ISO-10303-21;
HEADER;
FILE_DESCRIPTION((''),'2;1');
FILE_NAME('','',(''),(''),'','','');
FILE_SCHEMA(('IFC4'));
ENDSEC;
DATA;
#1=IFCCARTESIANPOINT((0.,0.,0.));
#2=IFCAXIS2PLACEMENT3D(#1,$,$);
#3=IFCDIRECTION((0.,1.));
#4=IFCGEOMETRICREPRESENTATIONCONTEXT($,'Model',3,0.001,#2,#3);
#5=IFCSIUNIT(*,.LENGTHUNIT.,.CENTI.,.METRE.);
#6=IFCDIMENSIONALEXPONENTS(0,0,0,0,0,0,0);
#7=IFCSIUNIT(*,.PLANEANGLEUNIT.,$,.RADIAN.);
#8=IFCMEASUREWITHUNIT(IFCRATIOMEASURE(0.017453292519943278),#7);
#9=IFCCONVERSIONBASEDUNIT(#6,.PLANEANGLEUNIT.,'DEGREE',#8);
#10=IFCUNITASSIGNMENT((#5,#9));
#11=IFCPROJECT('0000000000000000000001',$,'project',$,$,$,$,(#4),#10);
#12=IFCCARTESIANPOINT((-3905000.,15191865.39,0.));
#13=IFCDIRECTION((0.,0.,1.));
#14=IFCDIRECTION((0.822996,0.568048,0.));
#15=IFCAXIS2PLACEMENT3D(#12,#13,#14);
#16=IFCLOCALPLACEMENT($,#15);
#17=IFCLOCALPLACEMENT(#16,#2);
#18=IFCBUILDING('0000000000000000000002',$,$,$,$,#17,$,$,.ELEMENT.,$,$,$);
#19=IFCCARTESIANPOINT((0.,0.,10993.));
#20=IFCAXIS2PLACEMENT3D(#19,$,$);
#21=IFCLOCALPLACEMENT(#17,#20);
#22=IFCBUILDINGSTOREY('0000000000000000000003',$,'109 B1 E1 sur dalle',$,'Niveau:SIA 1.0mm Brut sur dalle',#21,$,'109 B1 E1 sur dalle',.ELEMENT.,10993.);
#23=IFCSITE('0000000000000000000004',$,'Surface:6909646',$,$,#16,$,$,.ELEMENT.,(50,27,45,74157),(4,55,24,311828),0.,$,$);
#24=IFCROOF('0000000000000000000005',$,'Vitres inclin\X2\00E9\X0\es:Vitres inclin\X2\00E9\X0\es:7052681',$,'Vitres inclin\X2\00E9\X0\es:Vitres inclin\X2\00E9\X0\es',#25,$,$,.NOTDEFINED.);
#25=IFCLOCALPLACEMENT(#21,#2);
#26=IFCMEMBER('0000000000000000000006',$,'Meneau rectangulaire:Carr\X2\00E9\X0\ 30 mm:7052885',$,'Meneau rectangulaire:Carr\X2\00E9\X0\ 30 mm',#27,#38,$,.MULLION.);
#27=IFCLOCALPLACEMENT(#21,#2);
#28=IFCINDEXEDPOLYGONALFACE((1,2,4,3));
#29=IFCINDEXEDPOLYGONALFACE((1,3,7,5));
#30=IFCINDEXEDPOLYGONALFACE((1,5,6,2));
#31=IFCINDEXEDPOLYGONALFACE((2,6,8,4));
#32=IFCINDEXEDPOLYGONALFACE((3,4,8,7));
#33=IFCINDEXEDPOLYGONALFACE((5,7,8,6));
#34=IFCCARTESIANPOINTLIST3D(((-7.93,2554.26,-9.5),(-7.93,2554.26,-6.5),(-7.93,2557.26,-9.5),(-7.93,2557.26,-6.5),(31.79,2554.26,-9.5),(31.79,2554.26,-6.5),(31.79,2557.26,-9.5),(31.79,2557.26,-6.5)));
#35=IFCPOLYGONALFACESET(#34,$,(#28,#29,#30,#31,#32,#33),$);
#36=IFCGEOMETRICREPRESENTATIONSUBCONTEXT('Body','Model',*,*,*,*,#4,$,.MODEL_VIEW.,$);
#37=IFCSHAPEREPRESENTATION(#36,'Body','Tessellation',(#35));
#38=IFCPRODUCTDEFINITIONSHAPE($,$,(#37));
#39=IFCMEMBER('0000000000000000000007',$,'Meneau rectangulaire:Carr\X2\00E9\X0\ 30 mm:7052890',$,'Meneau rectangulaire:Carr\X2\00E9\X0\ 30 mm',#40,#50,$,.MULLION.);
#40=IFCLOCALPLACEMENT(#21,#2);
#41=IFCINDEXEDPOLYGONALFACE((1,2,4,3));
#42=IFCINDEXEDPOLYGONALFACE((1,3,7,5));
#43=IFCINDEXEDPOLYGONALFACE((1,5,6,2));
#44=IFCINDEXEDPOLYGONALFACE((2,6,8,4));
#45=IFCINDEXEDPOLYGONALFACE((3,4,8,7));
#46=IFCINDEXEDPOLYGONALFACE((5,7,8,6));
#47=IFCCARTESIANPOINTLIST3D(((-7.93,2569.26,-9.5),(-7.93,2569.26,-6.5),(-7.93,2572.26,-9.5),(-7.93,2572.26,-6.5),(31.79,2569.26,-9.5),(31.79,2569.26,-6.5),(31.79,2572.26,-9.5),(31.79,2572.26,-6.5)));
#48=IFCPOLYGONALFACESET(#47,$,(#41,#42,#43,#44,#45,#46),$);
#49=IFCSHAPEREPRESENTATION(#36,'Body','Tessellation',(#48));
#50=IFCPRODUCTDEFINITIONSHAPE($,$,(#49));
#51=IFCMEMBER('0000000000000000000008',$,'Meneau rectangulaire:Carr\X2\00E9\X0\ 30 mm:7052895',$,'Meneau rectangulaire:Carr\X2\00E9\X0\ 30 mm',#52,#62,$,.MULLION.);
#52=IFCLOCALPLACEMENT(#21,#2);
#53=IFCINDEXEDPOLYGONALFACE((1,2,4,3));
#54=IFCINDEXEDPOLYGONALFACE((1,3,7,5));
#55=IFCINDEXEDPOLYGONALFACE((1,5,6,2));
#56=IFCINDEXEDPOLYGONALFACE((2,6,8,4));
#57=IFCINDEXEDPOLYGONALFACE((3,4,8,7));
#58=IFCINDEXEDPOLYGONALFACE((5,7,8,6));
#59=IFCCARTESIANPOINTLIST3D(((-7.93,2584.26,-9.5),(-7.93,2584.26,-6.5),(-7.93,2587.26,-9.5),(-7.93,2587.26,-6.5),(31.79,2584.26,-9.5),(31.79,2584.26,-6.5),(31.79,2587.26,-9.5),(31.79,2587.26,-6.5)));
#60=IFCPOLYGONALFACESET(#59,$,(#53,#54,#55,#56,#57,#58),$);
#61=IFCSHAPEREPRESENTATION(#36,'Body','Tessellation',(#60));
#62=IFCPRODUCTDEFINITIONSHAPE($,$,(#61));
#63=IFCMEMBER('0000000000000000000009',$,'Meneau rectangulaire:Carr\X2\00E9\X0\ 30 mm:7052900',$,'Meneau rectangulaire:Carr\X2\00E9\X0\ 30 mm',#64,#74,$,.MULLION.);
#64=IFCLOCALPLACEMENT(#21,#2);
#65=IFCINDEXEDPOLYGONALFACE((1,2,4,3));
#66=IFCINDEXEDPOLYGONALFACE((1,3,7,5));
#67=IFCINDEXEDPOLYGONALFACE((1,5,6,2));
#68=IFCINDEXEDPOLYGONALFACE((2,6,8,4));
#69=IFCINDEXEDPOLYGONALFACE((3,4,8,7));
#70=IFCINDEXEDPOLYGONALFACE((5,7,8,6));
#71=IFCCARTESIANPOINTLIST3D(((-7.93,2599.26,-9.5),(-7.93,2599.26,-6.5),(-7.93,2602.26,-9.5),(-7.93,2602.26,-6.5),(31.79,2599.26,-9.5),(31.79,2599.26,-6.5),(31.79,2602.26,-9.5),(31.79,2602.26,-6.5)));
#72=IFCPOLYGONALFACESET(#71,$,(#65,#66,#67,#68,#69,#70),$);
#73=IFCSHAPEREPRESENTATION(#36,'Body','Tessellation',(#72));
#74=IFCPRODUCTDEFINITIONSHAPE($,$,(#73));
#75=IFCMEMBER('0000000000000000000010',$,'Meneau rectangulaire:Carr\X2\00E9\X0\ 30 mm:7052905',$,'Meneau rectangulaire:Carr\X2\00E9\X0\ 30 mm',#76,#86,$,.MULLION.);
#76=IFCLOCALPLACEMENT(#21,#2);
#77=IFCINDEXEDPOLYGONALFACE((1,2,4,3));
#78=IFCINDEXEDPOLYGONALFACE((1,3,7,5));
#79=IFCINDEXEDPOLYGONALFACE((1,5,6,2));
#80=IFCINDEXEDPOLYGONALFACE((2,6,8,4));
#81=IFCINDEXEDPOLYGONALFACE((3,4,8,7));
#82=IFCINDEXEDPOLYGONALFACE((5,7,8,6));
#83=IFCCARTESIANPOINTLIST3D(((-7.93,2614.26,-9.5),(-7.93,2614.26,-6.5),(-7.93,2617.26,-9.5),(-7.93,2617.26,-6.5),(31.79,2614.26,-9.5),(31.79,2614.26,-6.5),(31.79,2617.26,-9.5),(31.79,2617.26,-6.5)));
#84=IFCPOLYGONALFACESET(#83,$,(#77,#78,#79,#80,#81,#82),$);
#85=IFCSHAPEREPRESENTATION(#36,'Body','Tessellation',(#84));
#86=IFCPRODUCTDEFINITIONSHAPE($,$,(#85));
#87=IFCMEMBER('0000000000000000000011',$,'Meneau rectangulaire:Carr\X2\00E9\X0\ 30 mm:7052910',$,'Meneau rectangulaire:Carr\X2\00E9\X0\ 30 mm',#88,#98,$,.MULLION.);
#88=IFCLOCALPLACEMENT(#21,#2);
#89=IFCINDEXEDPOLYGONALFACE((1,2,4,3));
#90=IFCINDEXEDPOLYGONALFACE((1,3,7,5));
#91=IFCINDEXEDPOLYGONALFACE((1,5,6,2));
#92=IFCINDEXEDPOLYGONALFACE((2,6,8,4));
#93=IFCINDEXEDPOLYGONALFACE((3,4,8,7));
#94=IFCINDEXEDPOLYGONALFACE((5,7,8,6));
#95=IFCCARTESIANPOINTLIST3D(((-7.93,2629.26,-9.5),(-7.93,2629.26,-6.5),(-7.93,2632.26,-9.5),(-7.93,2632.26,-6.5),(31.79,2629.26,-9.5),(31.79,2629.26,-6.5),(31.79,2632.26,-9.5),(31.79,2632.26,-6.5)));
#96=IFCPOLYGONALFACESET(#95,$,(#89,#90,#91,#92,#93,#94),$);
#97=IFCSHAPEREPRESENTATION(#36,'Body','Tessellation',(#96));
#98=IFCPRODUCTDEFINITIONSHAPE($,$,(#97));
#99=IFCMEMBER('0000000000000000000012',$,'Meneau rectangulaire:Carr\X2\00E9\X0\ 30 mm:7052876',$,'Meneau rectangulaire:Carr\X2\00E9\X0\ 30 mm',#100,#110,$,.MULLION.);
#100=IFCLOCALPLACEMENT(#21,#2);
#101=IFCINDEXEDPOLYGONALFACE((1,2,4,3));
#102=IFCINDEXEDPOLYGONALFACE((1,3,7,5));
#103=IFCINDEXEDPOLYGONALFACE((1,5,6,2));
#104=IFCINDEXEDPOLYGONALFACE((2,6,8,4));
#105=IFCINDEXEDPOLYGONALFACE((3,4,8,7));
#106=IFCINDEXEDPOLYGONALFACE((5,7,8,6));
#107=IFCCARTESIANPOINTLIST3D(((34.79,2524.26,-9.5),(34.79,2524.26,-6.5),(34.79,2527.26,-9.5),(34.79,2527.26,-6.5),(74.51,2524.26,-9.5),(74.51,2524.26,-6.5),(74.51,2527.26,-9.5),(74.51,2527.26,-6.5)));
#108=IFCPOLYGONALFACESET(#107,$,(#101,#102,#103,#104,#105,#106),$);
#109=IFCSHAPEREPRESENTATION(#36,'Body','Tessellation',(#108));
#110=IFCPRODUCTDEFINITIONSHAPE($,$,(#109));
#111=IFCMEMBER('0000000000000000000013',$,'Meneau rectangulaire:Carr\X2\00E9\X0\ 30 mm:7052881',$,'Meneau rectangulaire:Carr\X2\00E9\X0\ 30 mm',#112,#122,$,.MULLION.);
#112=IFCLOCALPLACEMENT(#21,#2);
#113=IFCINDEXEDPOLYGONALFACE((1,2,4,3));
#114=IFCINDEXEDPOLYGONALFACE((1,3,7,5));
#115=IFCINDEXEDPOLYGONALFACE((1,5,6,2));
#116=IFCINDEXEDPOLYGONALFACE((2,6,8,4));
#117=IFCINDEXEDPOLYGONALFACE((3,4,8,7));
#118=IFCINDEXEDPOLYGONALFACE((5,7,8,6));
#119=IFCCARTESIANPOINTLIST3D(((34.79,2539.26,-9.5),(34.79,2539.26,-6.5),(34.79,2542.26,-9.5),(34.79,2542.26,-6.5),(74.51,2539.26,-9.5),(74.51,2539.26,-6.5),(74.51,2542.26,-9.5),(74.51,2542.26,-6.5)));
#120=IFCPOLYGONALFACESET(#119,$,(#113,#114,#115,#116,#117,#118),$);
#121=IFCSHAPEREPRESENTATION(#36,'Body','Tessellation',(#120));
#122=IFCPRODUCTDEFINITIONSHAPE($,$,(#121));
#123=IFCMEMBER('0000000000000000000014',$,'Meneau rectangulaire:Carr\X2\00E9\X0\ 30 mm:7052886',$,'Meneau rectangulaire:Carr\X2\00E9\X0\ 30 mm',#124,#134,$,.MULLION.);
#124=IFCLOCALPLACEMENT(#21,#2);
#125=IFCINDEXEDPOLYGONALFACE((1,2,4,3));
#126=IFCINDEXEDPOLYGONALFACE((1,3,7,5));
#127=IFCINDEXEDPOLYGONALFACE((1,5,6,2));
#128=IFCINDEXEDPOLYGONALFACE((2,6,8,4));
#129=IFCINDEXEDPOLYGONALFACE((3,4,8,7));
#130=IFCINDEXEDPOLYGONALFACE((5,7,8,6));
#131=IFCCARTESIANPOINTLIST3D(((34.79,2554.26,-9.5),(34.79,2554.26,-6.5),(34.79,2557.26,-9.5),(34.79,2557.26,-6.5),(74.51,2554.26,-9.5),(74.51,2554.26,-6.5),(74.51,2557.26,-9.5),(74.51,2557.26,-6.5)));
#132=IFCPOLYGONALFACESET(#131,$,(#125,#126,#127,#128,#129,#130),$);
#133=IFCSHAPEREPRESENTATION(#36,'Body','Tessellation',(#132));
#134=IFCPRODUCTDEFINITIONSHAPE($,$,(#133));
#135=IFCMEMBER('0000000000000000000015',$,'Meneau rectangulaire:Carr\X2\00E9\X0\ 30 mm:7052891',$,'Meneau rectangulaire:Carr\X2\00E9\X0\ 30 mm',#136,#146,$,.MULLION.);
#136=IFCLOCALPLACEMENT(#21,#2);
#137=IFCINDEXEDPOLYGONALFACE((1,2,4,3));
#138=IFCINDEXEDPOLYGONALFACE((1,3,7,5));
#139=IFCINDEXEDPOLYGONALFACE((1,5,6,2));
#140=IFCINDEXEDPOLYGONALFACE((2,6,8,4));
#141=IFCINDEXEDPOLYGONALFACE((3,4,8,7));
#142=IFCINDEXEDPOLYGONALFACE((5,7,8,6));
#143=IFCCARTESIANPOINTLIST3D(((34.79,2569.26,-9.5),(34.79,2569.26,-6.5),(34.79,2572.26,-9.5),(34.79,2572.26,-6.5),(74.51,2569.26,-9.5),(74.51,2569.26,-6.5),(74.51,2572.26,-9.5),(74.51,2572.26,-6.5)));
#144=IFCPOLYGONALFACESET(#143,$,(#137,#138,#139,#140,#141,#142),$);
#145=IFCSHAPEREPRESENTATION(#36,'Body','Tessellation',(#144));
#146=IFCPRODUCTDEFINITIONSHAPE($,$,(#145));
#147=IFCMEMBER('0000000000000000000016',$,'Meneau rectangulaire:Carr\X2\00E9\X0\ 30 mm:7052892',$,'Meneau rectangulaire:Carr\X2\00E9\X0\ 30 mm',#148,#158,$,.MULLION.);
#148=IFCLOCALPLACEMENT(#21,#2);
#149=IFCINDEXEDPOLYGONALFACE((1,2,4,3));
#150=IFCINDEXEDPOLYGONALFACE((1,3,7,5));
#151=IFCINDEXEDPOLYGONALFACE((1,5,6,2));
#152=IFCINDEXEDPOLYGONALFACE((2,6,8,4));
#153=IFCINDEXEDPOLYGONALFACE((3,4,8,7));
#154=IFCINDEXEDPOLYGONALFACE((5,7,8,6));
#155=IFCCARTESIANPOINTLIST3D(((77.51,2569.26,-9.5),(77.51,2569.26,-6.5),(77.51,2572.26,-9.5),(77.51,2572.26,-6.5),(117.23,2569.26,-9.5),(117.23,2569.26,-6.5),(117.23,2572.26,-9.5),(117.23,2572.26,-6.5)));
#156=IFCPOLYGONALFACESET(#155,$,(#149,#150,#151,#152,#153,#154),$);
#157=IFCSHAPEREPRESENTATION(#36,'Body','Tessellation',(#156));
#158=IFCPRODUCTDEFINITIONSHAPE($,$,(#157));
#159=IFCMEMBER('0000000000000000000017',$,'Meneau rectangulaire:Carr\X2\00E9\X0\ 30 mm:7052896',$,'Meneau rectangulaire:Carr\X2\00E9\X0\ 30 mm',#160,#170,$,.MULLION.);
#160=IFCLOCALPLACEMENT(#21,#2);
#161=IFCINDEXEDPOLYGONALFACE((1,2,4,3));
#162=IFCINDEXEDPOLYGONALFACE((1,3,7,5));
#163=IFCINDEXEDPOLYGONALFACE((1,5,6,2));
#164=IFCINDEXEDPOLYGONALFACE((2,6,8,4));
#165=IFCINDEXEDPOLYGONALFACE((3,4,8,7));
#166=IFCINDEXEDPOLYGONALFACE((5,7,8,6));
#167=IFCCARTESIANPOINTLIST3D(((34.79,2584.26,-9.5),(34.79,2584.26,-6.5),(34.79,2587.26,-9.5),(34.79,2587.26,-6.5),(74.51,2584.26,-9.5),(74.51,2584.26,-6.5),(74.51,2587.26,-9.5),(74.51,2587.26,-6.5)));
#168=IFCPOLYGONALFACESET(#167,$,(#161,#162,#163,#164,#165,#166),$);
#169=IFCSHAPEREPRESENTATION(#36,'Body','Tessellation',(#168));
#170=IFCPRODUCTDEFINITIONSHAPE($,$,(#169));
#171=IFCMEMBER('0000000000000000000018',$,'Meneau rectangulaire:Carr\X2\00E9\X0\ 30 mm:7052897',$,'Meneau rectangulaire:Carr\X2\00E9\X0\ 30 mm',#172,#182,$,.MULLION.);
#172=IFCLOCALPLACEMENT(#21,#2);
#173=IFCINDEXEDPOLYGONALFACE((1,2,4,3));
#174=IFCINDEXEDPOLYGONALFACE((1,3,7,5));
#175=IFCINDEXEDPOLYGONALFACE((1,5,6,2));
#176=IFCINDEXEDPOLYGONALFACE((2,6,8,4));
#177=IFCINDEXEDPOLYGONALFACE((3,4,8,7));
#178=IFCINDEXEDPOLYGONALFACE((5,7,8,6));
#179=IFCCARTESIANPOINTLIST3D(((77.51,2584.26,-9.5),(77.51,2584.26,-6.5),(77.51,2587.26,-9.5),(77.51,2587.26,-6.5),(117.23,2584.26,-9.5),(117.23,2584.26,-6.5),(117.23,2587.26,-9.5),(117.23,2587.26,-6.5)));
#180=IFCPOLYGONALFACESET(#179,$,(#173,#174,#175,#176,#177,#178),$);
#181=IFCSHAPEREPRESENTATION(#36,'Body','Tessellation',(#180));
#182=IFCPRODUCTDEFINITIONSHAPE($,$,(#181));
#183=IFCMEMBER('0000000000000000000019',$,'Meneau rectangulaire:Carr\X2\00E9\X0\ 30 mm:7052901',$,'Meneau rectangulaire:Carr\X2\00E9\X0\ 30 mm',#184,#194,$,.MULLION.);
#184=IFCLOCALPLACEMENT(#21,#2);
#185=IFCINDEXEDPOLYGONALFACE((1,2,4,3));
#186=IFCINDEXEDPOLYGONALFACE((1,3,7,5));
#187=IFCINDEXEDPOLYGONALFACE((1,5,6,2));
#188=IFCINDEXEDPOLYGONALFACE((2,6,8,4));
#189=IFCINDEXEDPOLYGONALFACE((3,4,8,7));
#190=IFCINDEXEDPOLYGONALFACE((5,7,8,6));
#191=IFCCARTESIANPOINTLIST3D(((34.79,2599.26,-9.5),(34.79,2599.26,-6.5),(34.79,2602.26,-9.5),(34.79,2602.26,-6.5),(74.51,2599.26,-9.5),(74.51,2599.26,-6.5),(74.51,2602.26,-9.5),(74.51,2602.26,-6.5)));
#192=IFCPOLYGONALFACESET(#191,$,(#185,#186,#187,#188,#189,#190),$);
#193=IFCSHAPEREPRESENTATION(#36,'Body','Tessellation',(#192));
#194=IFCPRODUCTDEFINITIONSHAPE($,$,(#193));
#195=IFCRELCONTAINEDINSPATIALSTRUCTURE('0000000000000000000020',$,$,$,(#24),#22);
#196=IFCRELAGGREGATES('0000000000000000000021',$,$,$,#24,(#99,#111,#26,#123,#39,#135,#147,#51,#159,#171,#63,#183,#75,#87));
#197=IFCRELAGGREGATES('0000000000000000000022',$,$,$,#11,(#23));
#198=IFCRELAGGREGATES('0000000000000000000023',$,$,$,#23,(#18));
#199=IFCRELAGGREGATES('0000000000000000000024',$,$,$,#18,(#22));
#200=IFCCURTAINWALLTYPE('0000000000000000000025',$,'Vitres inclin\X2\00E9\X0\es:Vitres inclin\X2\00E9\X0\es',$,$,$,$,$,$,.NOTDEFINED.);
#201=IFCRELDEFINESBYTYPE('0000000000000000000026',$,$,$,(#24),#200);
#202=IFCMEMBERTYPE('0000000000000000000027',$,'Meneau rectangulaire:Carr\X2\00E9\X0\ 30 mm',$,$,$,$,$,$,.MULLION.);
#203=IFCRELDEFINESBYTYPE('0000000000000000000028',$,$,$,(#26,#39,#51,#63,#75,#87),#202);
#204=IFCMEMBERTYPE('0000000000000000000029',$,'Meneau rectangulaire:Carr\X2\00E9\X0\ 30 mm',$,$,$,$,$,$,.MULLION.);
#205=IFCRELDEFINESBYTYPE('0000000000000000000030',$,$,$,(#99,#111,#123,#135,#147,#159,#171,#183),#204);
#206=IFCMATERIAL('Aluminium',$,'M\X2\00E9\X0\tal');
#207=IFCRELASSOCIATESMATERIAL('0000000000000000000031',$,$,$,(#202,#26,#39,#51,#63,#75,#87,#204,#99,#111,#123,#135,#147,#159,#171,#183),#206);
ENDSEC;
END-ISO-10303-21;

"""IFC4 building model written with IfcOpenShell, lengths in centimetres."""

from ifc_helpers import new_model, entity, si_unit, converted_unit, direction, frame, origin, place, context, subcontext, project, spatial, indexed_curve, outline, extrude, source, transform, mapped, material, type_object, type_shapes, element, aggregate, save


model = new_model("IFC4")

# Units and contexts
model_context = context("Model", 3, precision=0.001, world=origin(), true_north=direction((0.0, 1.0)))
body_context = subcontext(model_context, "Body", "Model", "MODEL_VIEW")
ifc_project = project(units=[si_unit("LENGTHUNIT", "METRE", prefix="CENTI"), converted_unit("PLANEANGLEUNIT", "DEGREE", entity("IfcRatioMeasure", 0.017453292519943278), si_unit("PLANEANGLEUNIT", "RADIAN"), dimensions=[0, 0, 0, 0, 0, 0, 0])], contexts=[model_context])

# Site, building, storey
site_placement = place(None, frame((-3905000.0, 15191865.39, 0.0), z_axis=(0.0, 0.0, 1.0), x_axis=(0.822996, 0.568048, 0.0)))
site = spatial("IfcSite", under=ifc_project, at=site_placement, Name="Surface:6909646", CompositionType="ELEMENT", RefLatitude=(50, 27, 45, 74157), RefLongitude=(4, 55, 24, 311828), RefElevation=0.0)
building_placement = place(site_placement, origin())
building = spatial("IfcBuilding", under=site, at=building_placement, CompositionType="ELEMENT")
storey_placement = place(building_placement, frame((0.0, 0.0, 10993.0)))
storey = spatial("IfcBuildingStorey", under=building, at=storey_placement, Name="109 B1 E1 sur dalle", ObjectType="Niveau:SIA 1.0mm Brut sur dalle", LongName="109 B1 E1 sur dalle", CompositionType="ELEMENT", Elevation=10993.0)

# Roof, members
curtain_wall_type = type_object("IfcCurtainWallType", Name="Vitres inclinées:Vitres inclinées", PredefinedType="NOTDEFINED")
roof_placement = place(storey_placement, frame((0.0, 0.0, -10993.0)))
roof = element("IfcRoof", 1, at=roof_placement, inside=storey, type_object=curtain_wall_type, Name="Vitres inclinées:Vitres inclinées:7052681", ObjectType="Vitres inclinées:Vitres inclinées", PredefinedType="NOTDEFINED")
ifc_material = material(Name="Aluminium", Category="Métal")
member_type_1 = type_object("IfcMemberType", Name="Meneau rectangulaire:Carré 30 mm", PredefinedType="MULLION", material=ifc_material)
shared_shape_1 = source(origin(), body_context, "Body", "SweptSolid", [
    extrude(outline(indexed_curve([(-1.5, -1.5), (1.5, -1.5), (1.5, 1.5), (-1.5, 1.5), (-1.5, -1.5)], self_intersect=False)), frame((0.0, 0.0, -39.72), z_axis=(0.0, 0.0, 1.0), x_axis=(0.0, -1.0, 0.0)), (0.0, 0.0, 1.0), 39.72),
])
type_shapes(member_type_1, [shared_shape_1])
member_1_placement = place(roof_placement, frame((-7.93, 2555.76, 10985.0), z_axis=(-1.0, 0.0, 0.0), x_axis=(0.0, 1.0, 0.0)))
member_1 = element("IfcMember", 2, at=member_1_placement, type_object=member_type_1, material=ifc_material, Name="Meneau rectangulaire:Carré 30 mm:7052885", ObjectType="Meneau rectangulaire:Carré 30 mm", PredefinedType="MULLION", context=body_context, shape_type="MappedRepresentation", body=[
    mapped(shared_shape_1, transform((0.0, 0.0, 0.0), scale=1.0)),
])
member_2_placement = place(roof_placement, frame((-7.93, 2570.76, 10985.0), z_axis=(-1.0, 0.0, 0.0), x_axis=(0.0, 1.0, 0.0)))
member_2 = element("IfcMember", 3, at=member_2_placement, type_object=member_type_1, material=ifc_material, Name="Meneau rectangulaire:Carré 30 mm:7052890", ObjectType="Meneau rectangulaire:Carré 30 mm", PredefinedType="MULLION", context=body_context, shape_type="MappedRepresentation", body=[
    mapped(shared_shape_1, transform((0.0, 0.0, 0.0), scale=1.0)),
])
member_3_placement = place(roof_placement, frame((-7.93, 2585.76, 10985.0), z_axis=(-1.0, 0.0, 0.0), x_axis=(0.0, 1.0, 0.0)))
member_3 = element("IfcMember", 4, at=member_3_placement, type_object=member_type_1, material=ifc_material, Name="Meneau rectangulaire:Carré 30 mm:7052895", ObjectType="Meneau rectangulaire:Carré 30 mm", PredefinedType="MULLION", context=body_context, shape_type="MappedRepresentation", body=[
    mapped(shared_shape_1, transform((0.0, 0.0, 0.0), scale=1.0)),
])
member_4_placement = place(roof_placement, frame((-7.93, 2600.76, 10985.0), z_axis=(-1.0, 0.0, 0.0), x_axis=(0.0, 1.0, 0.0)))
member_4 = element("IfcMember", 5, at=member_4_placement, type_object=member_type_1, material=ifc_material, Name="Meneau rectangulaire:Carré 30 mm:7052900", ObjectType="Meneau rectangulaire:Carré 30 mm", PredefinedType="MULLION", context=body_context, shape_type="MappedRepresentation", body=[
    mapped(shared_shape_1, transform((0.0, 0.0, 0.0), scale=1.0)),
])
member_5_placement = place(roof_placement, frame((-7.93, 2615.76, 10985.0), z_axis=(-1.0, 0.0, 0.0), x_axis=(0.0, 1.0, 0.0)))
member_5 = element("IfcMember", 6, at=member_5_placement, type_object=member_type_1, material=ifc_material, Name="Meneau rectangulaire:Carré 30 mm:7052905", ObjectType="Meneau rectangulaire:Carré 30 mm", PredefinedType="MULLION", context=body_context, shape_type="MappedRepresentation", body=[
    mapped(shared_shape_1, transform((0.0, 0.0, 0.0), scale=1.0)),
])
member_6_placement = place(roof_placement, frame((-7.93, 2630.76, 10985.0), z_axis=(-1.0, 0.0, 0.0), x_axis=(0.0, 1.0, 0.0)))
member_6 = element("IfcMember", 7, at=member_6_placement, type_object=member_type_1, material=ifc_material, Name="Meneau rectangulaire:Carré 30 mm:7052910", ObjectType="Meneau rectangulaire:Carré 30 mm", PredefinedType="MULLION", context=body_context, shape_type="MappedRepresentation", body=[
    mapped(shared_shape_1, transform((0.0, 0.0, 0.0), scale=1.0)),
])
member_type_2 = type_object("IfcMemberType", Name="Meneau rectangulaire:Carré 30 mm", PredefinedType="MULLION", material=ifc_material)
shared_shape_2 = source(origin(), body_context, "Body", "SweptSolid", [
    extrude(outline(indexed_curve([(-1.5, -1.5), (1.5, -1.5), (1.5, 1.5), (-1.5, 1.5), (-1.5, -1.5)], self_intersect=False)), frame((0.0, 0.0, -39.72), z_axis=(0.0, 0.0, 1.0), x_axis=(0.0, -1.0, 0.0)), (0.0, 0.0, 1.0), 39.72),
])
type_shapes(member_type_2, [shared_shape_2])
member_7_placement = place(roof_placement, frame((34.79, 2525.76, 10985.0), z_axis=(-1.0, 0.0, 0.0), x_axis=(0.0, 1.0, 0.0)))
member_7 = element("IfcMember", 8, at=member_7_placement, type_object=member_type_2, material=ifc_material, Name="Meneau rectangulaire:Carré 30 mm:7052876", ObjectType="Meneau rectangulaire:Carré 30 mm", PredefinedType="MULLION", context=body_context, shape_type="MappedRepresentation", body=[
    mapped(shared_shape_2, transform((0.0, 0.0, 0.0), scale=1.0)),
])
member_8_placement = place(roof_placement, frame((34.79, 2540.76, 10985.0), z_axis=(-1.0, 0.0, 0.0), x_axis=(0.0, 1.0, 0.0)))
member_8 = element("IfcMember", 9, at=member_8_placement, type_object=member_type_2, material=ifc_material, Name="Meneau rectangulaire:Carré 30 mm:7052881", ObjectType="Meneau rectangulaire:Carré 30 mm", PredefinedType="MULLION", context=body_context, shape_type="MappedRepresentation", body=[
    mapped(shared_shape_2, transform((0.0, 0.0, 0.0), scale=1.0)),
])
member_9_placement = place(roof_placement, frame((34.79, 2555.76, 10985.0), z_axis=(-1.0, 0.0, 0.0), x_axis=(0.0, 1.0, 0.0)))
member_9 = element("IfcMember", 10, at=member_9_placement, type_object=member_type_2, material=ifc_material, Name="Meneau rectangulaire:Carré 30 mm:7052886", ObjectType="Meneau rectangulaire:Carré 30 mm", PredefinedType="MULLION", context=body_context, shape_type="MappedRepresentation", body=[
    mapped(shared_shape_2, transform((0.0, 0.0, 0.0), scale=1.0)),
])
member_10_placement = place(roof_placement, frame((34.79, 2570.76, 10985.0), z_axis=(-1.0, 0.0, 0.0), x_axis=(0.0, 1.0, 0.0)))
member_10 = element("IfcMember", 11, at=member_10_placement, type_object=member_type_2, material=ifc_material, Name="Meneau rectangulaire:Carré 30 mm:7052891", ObjectType="Meneau rectangulaire:Carré 30 mm", PredefinedType="MULLION", context=body_context, shape_type="MappedRepresentation", body=[
    mapped(shared_shape_2, transform((0.0, 0.0, 0.0), scale=1.0)),
])
member_11_placement = place(roof_placement, frame((77.51, 2570.76, 10985.0), z_axis=(-1.0, 0.0, 0.0), x_axis=(0.0, 1.0, 0.0)))
member_11 = element("IfcMember", 12, at=member_11_placement, type_object=member_type_2, material=ifc_material, Name="Meneau rectangulaire:Carré 30 mm:7052892", ObjectType="Meneau rectangulaire:Carré 30 mm", PredefinedType="MULLION", context=body_context, shape_type="MappedRepresentation", body=[
    mapped(shared_shape_2, transform((0.0, 0.0, 0.0), scale=1.0)),
])
member_12_placement = place(roof_placement, frame((34.79, 2585.76, 10985.0), z_axis=(-1.0, 0.0, 0.0), x_axis=(0.0, 1.0, 0.0)))
member_12 = element("IfcMember", 13, at=member_12_placement, type_object=member_type_2, material=ifc_material, Name="Meneau rectangulaire:Carré 30 mm:7052896", ObjectType="Meneau rectangulaire:Carré 30 mm", PredefinedType="MULLION", context=body_context, shape_type="MappedRepresentation", body=[
    mapped(shared_shape_2, transform((0.0, 0.0, 0.0), scale=1.0)),
])
member_13_placement = place(roof_placement, frame((77.51, 2585.76, 10985.0), z_axis=(-1.0, 0.0, 0.0), x_axis=(0.0, 1.0, 0.0)))
member_13 = element("IfcMember", 14, at=member_13_placement, type_object=member_type_2, material=ifc_material, Name="Meneau rectangulaire:Carré 30 mm:7052897", ObjectType="Meneau rectangulaire:Carré 30 mm", PredefinedType="MULLION", context=body_context, shape_type="MappedRepresentation", body=[
    mapped(shared_shape_2, transform((0.0, 0.0, 0.0), scale=1.0)),
])
member_14_placement = place(roof_placement, frame((34.79, 2600.76, 10985.0), z_axis=(-1.0, 0.0, 0.0), x_axis=(0.0, 1.0, 0.0)))
member_14 = element("IfcMember", 15, at=member_14_placement, type_object=member_type_2, material=ifc_material, Name="Meneau rectangulaire:Carré 30 mm:7052901", ObjectType="Meneau rectangulaire:Carré 30 mm", PredefinedType="MULLION", context=body_context, shape_type="MappedRepresentation", body=[
    mapped(shared_shape_2, transform((0.0, 0.0, 0.0), scale=1.0)),
])
aggregate(roof, [member_7, member_8, member_1, member_9, member_2, member_10, member_11, member_3, member_12, member_13, member_4, member_14, member_5, member_6])

save(model, "model.ifc")
